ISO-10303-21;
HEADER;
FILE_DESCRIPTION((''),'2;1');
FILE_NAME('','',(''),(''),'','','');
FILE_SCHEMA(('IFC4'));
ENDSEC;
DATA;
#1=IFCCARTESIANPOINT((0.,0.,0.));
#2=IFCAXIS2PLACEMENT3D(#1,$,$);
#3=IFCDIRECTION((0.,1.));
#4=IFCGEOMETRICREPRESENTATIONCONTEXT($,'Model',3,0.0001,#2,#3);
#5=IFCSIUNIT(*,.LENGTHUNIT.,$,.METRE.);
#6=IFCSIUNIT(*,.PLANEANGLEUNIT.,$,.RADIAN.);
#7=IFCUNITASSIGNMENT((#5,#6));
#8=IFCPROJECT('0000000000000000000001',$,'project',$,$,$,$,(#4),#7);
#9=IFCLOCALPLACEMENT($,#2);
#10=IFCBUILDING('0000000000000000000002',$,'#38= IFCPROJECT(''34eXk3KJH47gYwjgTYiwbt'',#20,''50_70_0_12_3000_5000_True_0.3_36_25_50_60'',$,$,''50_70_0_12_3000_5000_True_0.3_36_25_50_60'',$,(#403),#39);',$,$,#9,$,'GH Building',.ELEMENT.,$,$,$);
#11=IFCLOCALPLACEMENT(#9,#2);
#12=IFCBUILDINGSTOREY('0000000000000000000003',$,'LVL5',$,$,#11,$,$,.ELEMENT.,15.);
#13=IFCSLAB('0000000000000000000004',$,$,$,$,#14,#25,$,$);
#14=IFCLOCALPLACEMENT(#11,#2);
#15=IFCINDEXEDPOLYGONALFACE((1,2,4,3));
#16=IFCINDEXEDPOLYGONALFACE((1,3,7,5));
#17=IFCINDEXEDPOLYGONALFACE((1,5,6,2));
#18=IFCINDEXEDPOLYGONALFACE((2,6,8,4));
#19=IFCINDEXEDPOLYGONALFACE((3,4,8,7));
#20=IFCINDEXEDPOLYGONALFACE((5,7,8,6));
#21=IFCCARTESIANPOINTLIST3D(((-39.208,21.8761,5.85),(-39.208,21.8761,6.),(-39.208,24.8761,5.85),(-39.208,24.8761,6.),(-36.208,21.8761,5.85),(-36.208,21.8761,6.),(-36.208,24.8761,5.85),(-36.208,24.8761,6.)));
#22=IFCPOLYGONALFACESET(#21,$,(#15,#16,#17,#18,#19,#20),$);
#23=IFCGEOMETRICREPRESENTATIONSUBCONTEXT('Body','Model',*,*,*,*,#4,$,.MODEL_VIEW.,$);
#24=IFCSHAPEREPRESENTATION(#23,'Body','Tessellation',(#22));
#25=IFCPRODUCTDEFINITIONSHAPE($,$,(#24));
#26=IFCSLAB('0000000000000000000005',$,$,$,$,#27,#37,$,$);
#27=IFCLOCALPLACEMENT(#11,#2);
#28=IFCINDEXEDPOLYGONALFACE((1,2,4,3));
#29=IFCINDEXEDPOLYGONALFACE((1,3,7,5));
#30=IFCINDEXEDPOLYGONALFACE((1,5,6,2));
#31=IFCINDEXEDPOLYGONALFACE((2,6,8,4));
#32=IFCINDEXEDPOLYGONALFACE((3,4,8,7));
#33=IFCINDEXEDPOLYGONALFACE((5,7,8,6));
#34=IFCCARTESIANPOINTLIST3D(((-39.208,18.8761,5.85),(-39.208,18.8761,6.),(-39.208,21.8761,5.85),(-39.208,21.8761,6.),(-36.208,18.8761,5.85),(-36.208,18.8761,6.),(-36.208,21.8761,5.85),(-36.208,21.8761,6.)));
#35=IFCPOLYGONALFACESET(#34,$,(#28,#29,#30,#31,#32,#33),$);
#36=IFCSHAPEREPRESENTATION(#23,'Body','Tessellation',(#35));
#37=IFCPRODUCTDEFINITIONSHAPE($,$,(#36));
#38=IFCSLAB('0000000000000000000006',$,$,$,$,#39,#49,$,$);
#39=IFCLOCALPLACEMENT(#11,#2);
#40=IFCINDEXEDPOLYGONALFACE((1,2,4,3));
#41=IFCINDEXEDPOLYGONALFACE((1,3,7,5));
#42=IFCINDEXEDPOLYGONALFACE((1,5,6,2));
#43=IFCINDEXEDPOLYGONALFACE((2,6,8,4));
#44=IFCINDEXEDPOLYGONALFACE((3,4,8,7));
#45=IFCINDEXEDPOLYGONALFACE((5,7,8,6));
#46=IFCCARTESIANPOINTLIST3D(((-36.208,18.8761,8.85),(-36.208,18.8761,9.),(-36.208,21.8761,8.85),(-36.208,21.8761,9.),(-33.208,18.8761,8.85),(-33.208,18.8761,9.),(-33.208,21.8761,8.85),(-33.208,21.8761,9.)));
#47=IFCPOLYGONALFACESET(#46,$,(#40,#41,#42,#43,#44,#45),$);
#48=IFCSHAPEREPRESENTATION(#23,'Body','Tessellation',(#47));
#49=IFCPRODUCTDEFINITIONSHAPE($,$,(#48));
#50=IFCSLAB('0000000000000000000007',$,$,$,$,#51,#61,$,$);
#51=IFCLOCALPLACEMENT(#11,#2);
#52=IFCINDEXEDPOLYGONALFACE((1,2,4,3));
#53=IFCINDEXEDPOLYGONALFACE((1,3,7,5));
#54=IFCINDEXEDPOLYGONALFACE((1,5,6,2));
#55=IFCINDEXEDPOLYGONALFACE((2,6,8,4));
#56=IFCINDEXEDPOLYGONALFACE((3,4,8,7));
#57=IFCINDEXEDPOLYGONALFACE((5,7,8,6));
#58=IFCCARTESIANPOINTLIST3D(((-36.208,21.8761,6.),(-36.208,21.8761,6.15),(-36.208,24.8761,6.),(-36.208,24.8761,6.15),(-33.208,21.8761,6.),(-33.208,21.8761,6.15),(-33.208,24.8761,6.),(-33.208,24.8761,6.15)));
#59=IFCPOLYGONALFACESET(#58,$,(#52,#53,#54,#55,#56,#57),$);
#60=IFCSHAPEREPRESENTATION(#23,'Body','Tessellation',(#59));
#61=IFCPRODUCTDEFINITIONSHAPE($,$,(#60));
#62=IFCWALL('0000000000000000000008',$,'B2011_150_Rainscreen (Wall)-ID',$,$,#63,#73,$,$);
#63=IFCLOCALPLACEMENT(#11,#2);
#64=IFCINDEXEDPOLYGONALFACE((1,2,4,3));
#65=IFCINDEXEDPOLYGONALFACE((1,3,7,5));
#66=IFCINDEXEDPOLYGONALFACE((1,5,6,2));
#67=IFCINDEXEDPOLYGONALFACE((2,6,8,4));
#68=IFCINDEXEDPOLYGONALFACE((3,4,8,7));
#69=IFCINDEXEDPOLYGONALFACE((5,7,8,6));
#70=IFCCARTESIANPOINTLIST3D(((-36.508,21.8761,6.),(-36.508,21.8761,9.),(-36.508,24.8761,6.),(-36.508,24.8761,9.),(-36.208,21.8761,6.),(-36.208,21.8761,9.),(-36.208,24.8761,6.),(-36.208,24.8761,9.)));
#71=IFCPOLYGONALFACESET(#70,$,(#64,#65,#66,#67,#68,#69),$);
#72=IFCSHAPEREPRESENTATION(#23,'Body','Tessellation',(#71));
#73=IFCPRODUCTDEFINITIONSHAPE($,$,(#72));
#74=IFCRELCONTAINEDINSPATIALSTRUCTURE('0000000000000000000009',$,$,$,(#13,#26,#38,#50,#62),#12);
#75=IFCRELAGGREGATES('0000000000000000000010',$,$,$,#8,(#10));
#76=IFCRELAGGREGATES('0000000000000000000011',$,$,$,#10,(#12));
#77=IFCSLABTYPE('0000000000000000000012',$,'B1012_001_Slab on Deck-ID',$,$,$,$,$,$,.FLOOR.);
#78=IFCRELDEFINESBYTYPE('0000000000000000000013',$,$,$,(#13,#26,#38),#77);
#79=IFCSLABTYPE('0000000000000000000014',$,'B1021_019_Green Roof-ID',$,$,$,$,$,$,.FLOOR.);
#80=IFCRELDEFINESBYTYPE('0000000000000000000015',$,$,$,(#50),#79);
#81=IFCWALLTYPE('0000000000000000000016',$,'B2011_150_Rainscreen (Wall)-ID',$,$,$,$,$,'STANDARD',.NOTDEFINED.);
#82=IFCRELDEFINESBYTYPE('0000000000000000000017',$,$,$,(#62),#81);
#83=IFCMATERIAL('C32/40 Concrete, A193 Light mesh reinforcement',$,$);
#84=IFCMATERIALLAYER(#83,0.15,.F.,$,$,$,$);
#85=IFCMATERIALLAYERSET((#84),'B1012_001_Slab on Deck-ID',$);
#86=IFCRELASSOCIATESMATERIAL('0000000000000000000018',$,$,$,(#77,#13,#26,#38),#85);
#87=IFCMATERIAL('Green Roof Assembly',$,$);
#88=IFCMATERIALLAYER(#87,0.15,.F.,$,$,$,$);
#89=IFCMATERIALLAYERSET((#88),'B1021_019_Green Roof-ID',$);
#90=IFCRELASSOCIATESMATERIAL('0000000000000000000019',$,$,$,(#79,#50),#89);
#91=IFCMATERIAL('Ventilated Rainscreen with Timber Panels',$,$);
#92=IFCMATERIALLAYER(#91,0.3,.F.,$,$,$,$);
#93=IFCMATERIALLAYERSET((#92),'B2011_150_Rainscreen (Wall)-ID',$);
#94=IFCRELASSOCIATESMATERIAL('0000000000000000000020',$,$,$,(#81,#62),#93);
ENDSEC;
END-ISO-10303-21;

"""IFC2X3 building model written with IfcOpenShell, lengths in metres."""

from ifc_helpers import new_model, si_unit, direction, frame, frame_2d, origin, place, context, subcontext, project, spatial, polyline, rectangle, outline, extrude, material, layer, layer_set, layer_usage, type_object, element, save


model = new_model("IFC2X3")

# Units and contexts
model_context = context("Model", 3, precision=0.0001, world=origin(), true_north=direction((0.0, 1.0)))
body_context = subcontext(model_context, "Body", "Model", "MODEL_VIEW")
ifc_project = project(units=[si_unit("LENGTHUNIT", "METRE"), si_unit("PLANEANGLEUNIT", "RADIAN")], contexts=[model_context])

# Building, storey
building_placement = place(None, origin())
building = spatial("IfcBuilding", under=ifc_project, at=building_placement, Name="#38= IFCPROJECT('34eXk3KJH47gYwjgTYiwbt',#20,'50_70_0_12_3000_5000_True_0.3_36_25_50_60',$,$,'50_70_0_12_3000_5000_True_0.3_36_25_50_60',$,(#403),#39);", LongName="GH Building", CompositionType="ELEMENT")
storey_placement = place(building_placement, origin())
storey = spatial("IfcBuildingStorey", under=building, at=storey_placement, Name="LVL5", CompositionType="ELEMENT", Elevation=15.0)

# Slabs
ifc_material_1 = material(Name="C32/40 Concrete, A193 Light mesh reinforcement")
ifc_layer_1 = layer(ifc_material_1, 0.15, ventilated=False)
ifc_layer_set_1 = layer_set([ifc_layer_1], Name="B1012_001_Slab on Deck-ID")
slab_type_1 = type_object("IfcSlabType", Name="B1012_001_Slab on Deck-ID", PredefinedType="FLOOR", material=ifc_layer_set_1)
ifc_layer_usage_1 = layer_usage(ifc_layer_set_1, "AXIS3", "NEGATIVE", -0.15)
slab_1_placement = place(storey_placement, frame((-37.708, 23.3761, 5.85)))
element("IfcSlab", 1, at=slab_1_placement, inside=storey, type_object=slab_type_1, material=ifc_layer_usage_1, context=body_context, shape_type="SweptSolid", body=[
    extrude(outline(polyline([(1.5, 1.5), (1.5, -1.5), (-1.5, -1.5), (-1.5, 1.5), (1.5, 1.5)])), origin(), (0.0, 0.0, 1.0), 0.15),
])
ifc_layer_usage_2 = layer_usage(ifc_layer_set_1, "AXIS3", "NEGATIVE", -0.15)
slab_2_placement = place(storey_placement, frame((-37.708, 20.3761, 5.85)))
element("IfcSlab", 2, at=slab_2_placement, inside=storey, type_object=slab_type_1, material=ifc_layer_usage_2, context=body_context, shape_type="SweptSolid", body=[
    extrude(outline(polyline([(1.5, 1.5), (1.5, -1.5), (-1.5, -1.5), (-1.5, 1.5), (1.5, 1.5)])), origin(), (0.0, 0.0, 1.0), 0.15),
])
ifc_layer_usage_3 = layer_usage(ifc_layer_set_1, "AXIS3", "NEGATIVE", -0.15)
slab_3_placement = place(storey_placement, frame((-34.708, 20.3761, 8.85)))
element("IfcSlab", 3, at=slab_3_placement, inside=storey, type_object=slab_type_1, material=ifc_layer_usage_3, context=body_context, shape_type="SweptSolid", body=[
    extrude(outline(polyline([(1.5, 1.5), (1.5, -1.5), (-1.5, -1.5), (-1.5, 1.5), (1.5, 1.5)])), origin(), (0.0, 0.0, 1.0), 0.15),
])
ifc_material_2 = material(Name="Green Roof Assembly")
ifc_layer_2 = layer(ifc_material_2, 0.15, ventilated=False)
ifc_layer_set_2 = layer_set([ifc_layer_2], Name="B1021_019_Green Roof-ID")
ifc_layer_usage_4 = layer_usage(ifc_layer_set_2, "AXIS3", "NEGATIVE", -0.15)
slab_type_2 = type_object("IfcSlabType", Name="B1021_019_Green Roof-ID", PredefinedType="FLOOR", material=ifc_layer_set_2)
slab_4_placement = place(storey_placement, frame((-34.708, 23.3761, 6.0)))
element("IfcSlab", 4, at=slab_4_placement, inside=storey, type_object=slab_type_2, material=ifc_layer_usage_4, context=body_context, shape_type="SweptSolid", body=[
    extrude(outline(polyline([(1.5, -1.5), (-1.5, -1.5), (-1.5, 1.5), (1.5, 1.5), (1.5, -1.5)])), origin(), (0.0, 0.0, 1.0), 0.15),
])

# Wall
ifc_material_3 = material(Name="Ventilated Rainscreen with Timber Panels")
ifc_layer_3 = layer(ifc_material_3, 0.3, ventilated=False)
ifc_layer_set_3 = layer_set([ifc_layer_3], Name="B2011_150_Rainscreen (Wall)-ID")
ifc_layer_usage_5 = layer_usage(ifc_layer_set_3, "AXIS2", "POSITIVE", 0.0)
wall_type = type_object("IfcWallType", Name="B2011_150_Rainscreen (Wall)-ID", ElementType="STANDARD", PredefinedType="NOTDEFINED", material=ifc_layer_set_3)
wall_placement = place(storey_placement, frame((-36.208, 21.8761, 6.0), z_axis=(0.0, 0.0, 1.0), x_axis=(0.0, 1.0, 0.0)))
element("IfcWall", 5, at=wall_placement, inside=storey, type_object=wall_type, material=ifc_layer_usage_5, Name="B2011_150_Rainscreen (Wall)-ID", context=body_context, shape_type="SweptSolid", body=[
    extrude(rectangle(XDim=3.0, YDim=0.3, at=frame_2d((1.5, 0.15))), origin(), (0.0, 0.0, 1.0), 3.0),
])

save(model, "model.ifc")
